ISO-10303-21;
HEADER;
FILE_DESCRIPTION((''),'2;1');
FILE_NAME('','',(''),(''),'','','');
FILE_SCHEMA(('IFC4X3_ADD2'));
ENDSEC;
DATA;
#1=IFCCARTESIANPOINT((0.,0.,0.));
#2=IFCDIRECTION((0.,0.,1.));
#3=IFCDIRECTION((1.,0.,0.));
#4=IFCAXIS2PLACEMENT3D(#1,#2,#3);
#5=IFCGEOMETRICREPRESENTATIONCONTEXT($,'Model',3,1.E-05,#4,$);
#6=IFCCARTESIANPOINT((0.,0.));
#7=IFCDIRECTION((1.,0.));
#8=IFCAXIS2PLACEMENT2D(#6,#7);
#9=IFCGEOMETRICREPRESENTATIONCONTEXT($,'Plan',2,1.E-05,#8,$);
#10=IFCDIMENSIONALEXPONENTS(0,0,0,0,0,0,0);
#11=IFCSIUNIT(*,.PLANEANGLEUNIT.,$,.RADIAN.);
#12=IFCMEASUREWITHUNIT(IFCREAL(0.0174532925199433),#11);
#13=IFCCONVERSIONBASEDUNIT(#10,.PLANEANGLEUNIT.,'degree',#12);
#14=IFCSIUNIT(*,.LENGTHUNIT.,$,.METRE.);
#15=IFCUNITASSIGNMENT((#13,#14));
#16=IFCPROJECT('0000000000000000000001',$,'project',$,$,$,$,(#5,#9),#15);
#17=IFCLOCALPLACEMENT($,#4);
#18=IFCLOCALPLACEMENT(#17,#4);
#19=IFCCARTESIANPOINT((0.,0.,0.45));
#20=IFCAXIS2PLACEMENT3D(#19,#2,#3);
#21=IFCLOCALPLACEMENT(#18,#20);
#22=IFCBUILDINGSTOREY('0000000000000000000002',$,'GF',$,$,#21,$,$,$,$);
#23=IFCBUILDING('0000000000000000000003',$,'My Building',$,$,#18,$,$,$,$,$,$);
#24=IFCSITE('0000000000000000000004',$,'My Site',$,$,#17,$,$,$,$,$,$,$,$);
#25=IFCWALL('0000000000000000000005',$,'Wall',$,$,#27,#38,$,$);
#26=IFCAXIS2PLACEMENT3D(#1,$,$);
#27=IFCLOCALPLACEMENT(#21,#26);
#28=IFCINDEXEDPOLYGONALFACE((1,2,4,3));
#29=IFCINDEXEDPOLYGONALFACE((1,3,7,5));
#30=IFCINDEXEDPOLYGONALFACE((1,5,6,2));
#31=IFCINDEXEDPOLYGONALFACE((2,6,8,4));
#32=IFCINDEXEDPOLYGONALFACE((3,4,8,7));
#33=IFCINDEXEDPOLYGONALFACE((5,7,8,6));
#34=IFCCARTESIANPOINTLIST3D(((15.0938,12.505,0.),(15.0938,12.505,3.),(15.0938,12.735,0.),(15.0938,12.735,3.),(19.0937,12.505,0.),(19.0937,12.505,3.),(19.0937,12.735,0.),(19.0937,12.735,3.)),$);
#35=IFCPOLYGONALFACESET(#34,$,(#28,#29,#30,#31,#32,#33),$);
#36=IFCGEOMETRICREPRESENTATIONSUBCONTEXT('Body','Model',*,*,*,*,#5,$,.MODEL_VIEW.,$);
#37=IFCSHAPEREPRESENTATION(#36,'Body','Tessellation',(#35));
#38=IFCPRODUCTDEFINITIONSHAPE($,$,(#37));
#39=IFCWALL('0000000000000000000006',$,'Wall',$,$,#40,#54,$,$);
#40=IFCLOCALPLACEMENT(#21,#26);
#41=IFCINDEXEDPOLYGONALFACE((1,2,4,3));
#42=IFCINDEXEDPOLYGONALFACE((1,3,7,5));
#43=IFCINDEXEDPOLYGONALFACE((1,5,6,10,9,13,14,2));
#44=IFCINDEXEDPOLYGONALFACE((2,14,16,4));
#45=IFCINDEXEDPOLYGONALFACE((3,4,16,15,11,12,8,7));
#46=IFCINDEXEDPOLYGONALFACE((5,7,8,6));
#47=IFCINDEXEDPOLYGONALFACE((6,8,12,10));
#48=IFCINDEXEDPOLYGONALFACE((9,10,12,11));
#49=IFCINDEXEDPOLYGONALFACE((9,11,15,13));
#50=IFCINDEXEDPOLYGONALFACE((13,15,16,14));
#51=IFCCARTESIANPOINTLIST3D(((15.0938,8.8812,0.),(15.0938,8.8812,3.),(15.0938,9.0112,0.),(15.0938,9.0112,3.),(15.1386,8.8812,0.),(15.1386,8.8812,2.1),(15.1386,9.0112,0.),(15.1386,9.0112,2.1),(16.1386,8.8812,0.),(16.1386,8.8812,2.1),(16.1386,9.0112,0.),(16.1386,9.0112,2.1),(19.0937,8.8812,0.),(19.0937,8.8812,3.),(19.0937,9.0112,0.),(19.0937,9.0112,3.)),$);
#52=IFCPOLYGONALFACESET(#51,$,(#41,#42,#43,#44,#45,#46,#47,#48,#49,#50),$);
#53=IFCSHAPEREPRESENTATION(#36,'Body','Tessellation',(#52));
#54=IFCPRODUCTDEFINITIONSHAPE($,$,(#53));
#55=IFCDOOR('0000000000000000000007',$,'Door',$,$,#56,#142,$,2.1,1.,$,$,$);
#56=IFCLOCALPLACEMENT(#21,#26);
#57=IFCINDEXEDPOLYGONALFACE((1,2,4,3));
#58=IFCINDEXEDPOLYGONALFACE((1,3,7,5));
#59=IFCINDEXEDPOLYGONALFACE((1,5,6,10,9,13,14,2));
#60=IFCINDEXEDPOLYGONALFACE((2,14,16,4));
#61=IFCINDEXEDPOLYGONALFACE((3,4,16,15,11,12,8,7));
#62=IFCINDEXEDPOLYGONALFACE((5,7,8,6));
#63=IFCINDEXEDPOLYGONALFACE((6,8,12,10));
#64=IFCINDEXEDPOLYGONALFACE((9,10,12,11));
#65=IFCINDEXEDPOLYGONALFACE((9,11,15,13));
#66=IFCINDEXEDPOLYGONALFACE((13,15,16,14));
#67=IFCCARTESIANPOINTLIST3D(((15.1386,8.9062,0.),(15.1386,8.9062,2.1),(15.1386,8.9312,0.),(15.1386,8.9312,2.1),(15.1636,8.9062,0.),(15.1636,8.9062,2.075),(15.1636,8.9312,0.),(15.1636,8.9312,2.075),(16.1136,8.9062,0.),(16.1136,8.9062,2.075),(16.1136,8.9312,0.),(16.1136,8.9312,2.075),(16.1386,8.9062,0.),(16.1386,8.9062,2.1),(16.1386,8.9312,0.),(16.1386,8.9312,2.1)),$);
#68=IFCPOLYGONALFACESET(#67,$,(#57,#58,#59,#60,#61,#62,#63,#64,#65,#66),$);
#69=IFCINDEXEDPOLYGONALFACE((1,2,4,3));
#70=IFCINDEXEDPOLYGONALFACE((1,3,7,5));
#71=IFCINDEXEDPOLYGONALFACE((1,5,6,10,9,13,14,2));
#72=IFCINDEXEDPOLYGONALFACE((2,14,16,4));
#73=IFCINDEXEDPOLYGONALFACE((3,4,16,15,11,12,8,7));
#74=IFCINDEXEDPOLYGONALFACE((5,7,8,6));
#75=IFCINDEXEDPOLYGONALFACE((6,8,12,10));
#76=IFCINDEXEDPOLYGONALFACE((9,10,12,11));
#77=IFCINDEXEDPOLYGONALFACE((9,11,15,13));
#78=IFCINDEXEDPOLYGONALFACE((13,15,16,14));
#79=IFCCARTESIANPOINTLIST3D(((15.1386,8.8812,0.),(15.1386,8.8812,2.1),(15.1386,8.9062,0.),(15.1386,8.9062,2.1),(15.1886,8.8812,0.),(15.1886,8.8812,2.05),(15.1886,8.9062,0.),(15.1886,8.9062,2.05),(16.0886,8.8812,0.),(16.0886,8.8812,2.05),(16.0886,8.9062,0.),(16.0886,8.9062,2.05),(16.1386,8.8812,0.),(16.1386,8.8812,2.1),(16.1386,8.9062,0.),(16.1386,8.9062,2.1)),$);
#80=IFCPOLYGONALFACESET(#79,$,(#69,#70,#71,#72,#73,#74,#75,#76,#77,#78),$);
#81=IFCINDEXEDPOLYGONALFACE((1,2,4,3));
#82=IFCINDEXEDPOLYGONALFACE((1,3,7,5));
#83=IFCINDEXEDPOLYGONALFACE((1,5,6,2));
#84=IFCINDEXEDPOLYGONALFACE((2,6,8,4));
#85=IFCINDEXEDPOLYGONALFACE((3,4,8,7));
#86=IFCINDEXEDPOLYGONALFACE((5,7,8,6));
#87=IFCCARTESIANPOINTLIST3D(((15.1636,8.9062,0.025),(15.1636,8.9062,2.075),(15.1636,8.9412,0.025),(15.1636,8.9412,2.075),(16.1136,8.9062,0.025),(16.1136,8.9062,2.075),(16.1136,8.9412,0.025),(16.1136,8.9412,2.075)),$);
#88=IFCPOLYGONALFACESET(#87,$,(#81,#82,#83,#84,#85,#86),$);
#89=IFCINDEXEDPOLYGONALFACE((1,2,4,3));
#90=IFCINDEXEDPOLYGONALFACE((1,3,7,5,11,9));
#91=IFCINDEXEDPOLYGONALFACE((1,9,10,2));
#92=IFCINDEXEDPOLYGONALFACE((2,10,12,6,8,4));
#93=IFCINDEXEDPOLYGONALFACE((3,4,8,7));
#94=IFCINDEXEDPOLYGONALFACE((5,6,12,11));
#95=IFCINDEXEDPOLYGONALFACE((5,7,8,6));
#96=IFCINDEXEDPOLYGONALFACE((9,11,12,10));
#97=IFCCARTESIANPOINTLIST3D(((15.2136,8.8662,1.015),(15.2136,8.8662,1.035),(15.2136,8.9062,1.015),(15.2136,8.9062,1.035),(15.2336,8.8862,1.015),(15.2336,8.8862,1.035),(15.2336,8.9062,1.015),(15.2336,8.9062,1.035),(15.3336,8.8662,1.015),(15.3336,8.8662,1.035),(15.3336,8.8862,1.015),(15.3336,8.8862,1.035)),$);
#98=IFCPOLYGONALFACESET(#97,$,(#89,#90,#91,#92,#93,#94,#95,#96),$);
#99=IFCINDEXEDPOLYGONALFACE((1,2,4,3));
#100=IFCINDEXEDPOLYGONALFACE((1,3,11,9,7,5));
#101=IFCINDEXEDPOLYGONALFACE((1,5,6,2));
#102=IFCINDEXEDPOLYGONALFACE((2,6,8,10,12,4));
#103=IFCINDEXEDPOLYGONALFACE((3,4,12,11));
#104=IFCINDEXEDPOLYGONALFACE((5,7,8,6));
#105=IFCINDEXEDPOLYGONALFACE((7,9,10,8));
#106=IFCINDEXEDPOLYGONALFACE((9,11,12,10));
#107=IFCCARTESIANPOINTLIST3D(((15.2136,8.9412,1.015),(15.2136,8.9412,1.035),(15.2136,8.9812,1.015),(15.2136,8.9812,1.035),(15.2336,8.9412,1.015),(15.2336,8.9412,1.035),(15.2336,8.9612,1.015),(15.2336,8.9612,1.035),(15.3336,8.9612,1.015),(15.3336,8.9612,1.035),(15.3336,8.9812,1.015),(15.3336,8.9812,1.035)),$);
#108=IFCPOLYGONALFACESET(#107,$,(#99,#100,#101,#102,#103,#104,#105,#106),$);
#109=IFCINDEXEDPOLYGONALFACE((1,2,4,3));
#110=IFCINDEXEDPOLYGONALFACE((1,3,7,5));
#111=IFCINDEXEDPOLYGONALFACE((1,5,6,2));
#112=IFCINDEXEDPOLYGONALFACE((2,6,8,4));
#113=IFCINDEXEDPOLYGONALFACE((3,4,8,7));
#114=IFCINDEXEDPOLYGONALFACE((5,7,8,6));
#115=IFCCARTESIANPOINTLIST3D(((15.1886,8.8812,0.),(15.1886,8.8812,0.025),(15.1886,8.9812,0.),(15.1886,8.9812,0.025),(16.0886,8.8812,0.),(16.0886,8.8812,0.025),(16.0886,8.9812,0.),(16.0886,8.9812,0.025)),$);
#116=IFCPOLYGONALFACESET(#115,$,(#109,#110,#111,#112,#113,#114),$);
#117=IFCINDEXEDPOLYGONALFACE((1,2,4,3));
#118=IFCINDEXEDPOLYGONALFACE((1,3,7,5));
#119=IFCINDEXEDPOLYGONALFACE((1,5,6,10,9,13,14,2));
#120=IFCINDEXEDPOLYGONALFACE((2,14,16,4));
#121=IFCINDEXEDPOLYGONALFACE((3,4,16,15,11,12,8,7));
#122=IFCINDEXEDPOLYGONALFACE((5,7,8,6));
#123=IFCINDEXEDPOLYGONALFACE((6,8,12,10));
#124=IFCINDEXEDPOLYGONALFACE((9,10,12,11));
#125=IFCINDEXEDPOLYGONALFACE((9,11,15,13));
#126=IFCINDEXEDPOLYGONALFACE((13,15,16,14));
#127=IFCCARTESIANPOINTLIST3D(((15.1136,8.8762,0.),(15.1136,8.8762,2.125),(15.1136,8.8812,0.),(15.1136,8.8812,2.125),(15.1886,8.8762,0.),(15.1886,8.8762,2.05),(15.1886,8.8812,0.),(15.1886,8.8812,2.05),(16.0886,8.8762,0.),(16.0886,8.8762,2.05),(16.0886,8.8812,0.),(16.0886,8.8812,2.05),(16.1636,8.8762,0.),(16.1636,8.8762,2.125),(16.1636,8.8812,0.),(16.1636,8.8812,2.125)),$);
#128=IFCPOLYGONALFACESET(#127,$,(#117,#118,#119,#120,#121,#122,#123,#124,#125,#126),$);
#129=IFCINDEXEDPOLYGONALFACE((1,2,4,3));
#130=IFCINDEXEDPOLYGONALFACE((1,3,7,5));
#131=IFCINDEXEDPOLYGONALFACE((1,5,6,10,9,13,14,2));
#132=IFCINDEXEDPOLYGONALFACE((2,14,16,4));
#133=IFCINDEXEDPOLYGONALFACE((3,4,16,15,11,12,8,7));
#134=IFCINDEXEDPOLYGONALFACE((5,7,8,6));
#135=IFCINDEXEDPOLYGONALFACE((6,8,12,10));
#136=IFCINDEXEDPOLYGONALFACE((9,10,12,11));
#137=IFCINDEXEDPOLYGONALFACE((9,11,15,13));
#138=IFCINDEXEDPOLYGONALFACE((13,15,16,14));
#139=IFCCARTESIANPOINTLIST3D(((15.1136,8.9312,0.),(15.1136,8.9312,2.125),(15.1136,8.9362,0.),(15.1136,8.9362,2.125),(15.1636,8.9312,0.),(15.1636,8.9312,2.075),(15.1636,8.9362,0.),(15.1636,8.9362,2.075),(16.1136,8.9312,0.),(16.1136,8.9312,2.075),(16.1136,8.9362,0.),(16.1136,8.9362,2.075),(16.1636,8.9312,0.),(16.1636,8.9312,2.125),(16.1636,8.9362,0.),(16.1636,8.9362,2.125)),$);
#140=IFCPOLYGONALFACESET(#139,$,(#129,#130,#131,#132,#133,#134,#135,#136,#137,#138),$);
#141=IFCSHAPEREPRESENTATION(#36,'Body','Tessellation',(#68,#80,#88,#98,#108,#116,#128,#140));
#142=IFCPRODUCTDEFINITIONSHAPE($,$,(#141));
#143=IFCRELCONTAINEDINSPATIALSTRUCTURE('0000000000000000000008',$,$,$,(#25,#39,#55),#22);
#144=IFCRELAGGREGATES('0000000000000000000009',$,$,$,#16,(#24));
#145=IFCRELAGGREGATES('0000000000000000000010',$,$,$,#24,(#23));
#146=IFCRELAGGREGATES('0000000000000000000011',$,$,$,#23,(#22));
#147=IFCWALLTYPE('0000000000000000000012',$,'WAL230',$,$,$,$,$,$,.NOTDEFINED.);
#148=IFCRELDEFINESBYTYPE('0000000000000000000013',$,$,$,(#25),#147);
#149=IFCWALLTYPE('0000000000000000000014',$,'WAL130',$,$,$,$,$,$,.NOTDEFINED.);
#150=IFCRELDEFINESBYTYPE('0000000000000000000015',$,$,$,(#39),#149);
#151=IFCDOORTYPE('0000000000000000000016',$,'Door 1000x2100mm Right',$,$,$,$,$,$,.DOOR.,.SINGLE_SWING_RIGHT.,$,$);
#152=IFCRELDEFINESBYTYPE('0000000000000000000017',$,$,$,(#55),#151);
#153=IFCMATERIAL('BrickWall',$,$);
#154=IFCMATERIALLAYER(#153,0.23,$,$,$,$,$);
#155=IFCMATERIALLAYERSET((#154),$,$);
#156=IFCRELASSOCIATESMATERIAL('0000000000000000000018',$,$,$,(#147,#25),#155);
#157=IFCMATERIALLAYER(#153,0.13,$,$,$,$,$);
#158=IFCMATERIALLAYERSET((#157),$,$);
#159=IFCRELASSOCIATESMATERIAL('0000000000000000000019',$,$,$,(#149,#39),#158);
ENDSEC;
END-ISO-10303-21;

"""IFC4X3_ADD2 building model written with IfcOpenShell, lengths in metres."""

from ifc_helpers import new_model, entity, si_unit, converted_unit, frame, origin_with_axes, origin_2d_with_axis, place, context, subcontext, project, spatial, line, indexed_curve, outline, extrude, shape, source, transform, mapped, material, layer, layer_set, layer_usage, type_object, type_shapes, element, fill, save


model = new_model("IFC4X3_ADD2")

# Units and contexts
model_context = context("Model", 3, precision=1e-05, world=origin_with_axes())
plan_context = context("Plan", 2, precision=1e-05, world=origin_2d_with_axis())
body_context_1 = subcontext(model_context, "Body", "Model", "MODEL_VIEW")
body_context_2 = subcontext(plan_context, "Body", "Plan", "PLAN_VIEW")
ifc_project = project(units=[converted_unit("PLANEANGLEUNIT", "degree", entity("IfcReal", 0.0174532925199433), si_unit("PLANEANGLEUNIT", "RADIAN"), dimensions=[0, 0, 0, 0, 0, 0, 0]), si_unit("LENGTHUNIT", "METRE")], contexts=[model_context, plan_context])

# Site, building, storey
site_placement = place(None, origin_with_axes())
site = spatial("IfcSite", under=ifc_project, at=site_placement, Name="My Site")
building_placement = place(site_placement, origin_with_axes())
building = spatial("IfcBuilding", under=site, at=building_placement, Name="My Building")
storey_placement = place(building_placement, frame((0.0, 0.0, 0.45), z_axis=(0.0, 0.0, 1.0), x_axis=(1.0, 0.0, 0.0)))
storey = spatial("IfcBuildingStorey", under=building, at=storey_placement, Name="GF")

# Shared definitions
ifc_material_1 = material(Name="BrickWall")
ifc_layer_1 = layer(ifc_material_1, 0.23)
ifc_layer_set_1 = layer_set([ifc_layer_1])
wall_type_1 = type_object("IfcWallType", Name="WAL230", PredefinedType="NOTDEFINED", material=ifc_layer_set_1)

# Wall
ifc_layer_usage_1 = layer_usage(ifc_layer_set_1, "AXIS2", "POSITIVE", 0.0)
wall_1_placement = place(storey_placement, frame((19.0937, 12.735, 0.0), z_axis=(0.0, 0.0, 1.0), x_axis=(-1.0, 0.0, 0.0)))
element("IfcWall", 1, at=wall_1_placement, inside=storey, type_object=wall_type_1, material=ifc_layer_usage_1, Name="Wall", context=body_context_1, shape_type="SweptSolid", body=[
    extrude(outline(indexed_curve([(0.0, 0.0), (0.0, 0.23), (3.9999, 0.23), (3.9999, 0.0), (0.0, 0.0)], self_intersect=False)), origin_with_axes(), (0.0, 0.0, 1.0), 3.0),
])

# Wall, opening, door
ifc_layer_2 = layer(ifc_material_1, 0.13)
ifc_layer_set_2 = layer_set([ifc_layer_2])
ifc_layer_usage_2 = layer_usage(ifc_layer_set_2, "AXIS2", "POSITIVE", 0.0)
wall_type_2 = type_object("IfcWallType", Name="WAL130", PredefinedType="NOTDEFINED", material=ifc_layer_set_2)
wall_2_placement = place(storey_placement, frame((15.0938, 8.8812, 0.0), z_axis=(0.0, 0.0, 1.0), x_axis=(1.0, 0.0, 0.0)))
wall_2 = element("IfcWall", 2, at=wall_2_placement, inside=storey, type_object=wall_type_2, material=ifc_layer_usage_2, Name="Wall", context=body_context_1, shape_type="SweptSolid", body=[
    extrude(outline(indexed_curve([(0.0, 0.0), (0.0, 0.13), (3.9999, 0.13), (3.9999, 0.0), (0.0, 0.0)], self_intersect=False)), origin_with_axes(), (0.0, 0.0, 1.0), 3.0),
])
shared_shape_1 = source(origin_with_axes(), body_context_1, "Body", "SweptSolid", [
    extrude(outline(indexed_curve([(0.0, 0.0), (1.0, 0.0), (1.0, 2.1), (0.0, 2.1)], segments=[line(1, 2, 3, 4, 1)])), frame((0.0, -0.6, 0.0), z_axis=(0.0, -1.0, 0.0), x_axis=(1.0, 0.0, 0.0)), (0.0, 0.0, -1.0), 1.2),
])
opening_1_placement = place(wall_2_placement, frame((0.0447, 0.0, 0.0), z_axis=(0.0, 0.0, 1.0), x_axis=(1.0, 0.0, 0.0)))
opening_1 = element("IfcOpeningElement", 3, at=opening_1_placement, cuts=wall_2, PredefinedType="OPENING", context=body_context_1, shape_type="MappedRepresentation", body=[
    mapped(shared_shape_1, transform((0.0, 0.0, 0.0), x_axis=(1.0, 0.0, 0.0), y_axis=(0.0, 1.0, 0.0), z_axis=(0.0, 0.0, 1.0), scale=1.0)),
])
door_type_1 = type_object("IfcDoorType", Name="Door 1000x2100mm Right", OperationType="SINGLE_SWING_RIGHT", PredefinedType="DOOR")
shared_shape_2 = source(origin_with_axes(), body_context_1, "Body", "SweptSolid", [
    extrude(outline(indexed_curve([(0.0, 0.0), (0.0, 2.1), (1.0, 2.1), (1.0, 0.0), (0.975, 0.0), (0.975, 2.075), (0.025, 2.075), (0.025, 0.0)], segments=[line(1, 2, 3, 4, 5, 6, 7, 8, 1)])), frame((0.0, 0.025, 0.0), z_axis=(0.0, -1.0, 0.0), x_axis=(1.0, 0.0, 0.0)), (0.0, 0.0, -1.0), 0.025),
    extrude(outline(indexed_curve([(0.0, 0.0), (0.0, 2.1), (1.0, 2.1), (1.0, 0.0), (0.95, 0.0), (0.95, 2.05), (0.05, 2.05), (0.05, 0.0)], segments=[line(1, 2, 3, 4, 5, 6, 7, 8, 1)])), frame((0.0, 0.0, 0.0), z_axis=(0.0, -1.0, 0.0), x_axis=(1.0, 0.0, 0.0)), (0.0, 0.0, -1.0), 0.025),
    extrude(outline(indexed_curve([(0.0, 0.0), (0.95, 0.0), (0.95, 0.035), (0.0, 0.035)], segments=[line(1, 2, 3, 4, 1)])), frame((0.025, 0.025, 0.025), z_axis=(0.0, 0.0, 1.0), x_axis=(1.0, 0.0, 0.0)), (0.0, 0.0, 1.0), 2.05),
    extrude(outline(indexed_curve([(0.0, 0.0), (0.0, -0.04), (0.12, -0.04), (0.12, -0.02), (0.02, -0.02), (0.02, 0.0)], segments=[line(1, 2, 3, 4, 5, 6, 1)])), frame((0.075, 0.025, 1.015), z_axis=(0.0, 0.0, 1.0), x_axis=(1.0, 0.0, 0.0)), (0.0, 0.0, 1.0), 0.02),
    extrude(outline(indexed_curve([(0.0, 0.0), (0.0, 0.04), (0.12, 0.04), (0.12, 0.02), (0.02, 0.02), (0.02, 0.0)], segments=[line(1, 2, 3, 4, 5, 6, 1)])), frame((0.075, 0.06, 1.015), z_axis=(0.0, 0.0, 1.0), x_axis=(1.0, 0.0, 0.0)), (0.0, 0.0, 1.0), 0.02),
    extrude(outline(indexed_curve([(0.0, 0.0), (0.9, 0.0), (0.9, 0.1), (0.0, 0.1)], segments=[line(1, 2, 3, 4, 1)])), frame((0.05, 0.0, 0.0), z_axis=(0.0, 0.0, 1.0), x_axis=(1.0, 0.0, 0.0)), (0.0, 0.0, 1.0), 0.025),
    extrude(outline(indexed_curve([(0.0, 0.0), (0.0, 2.125), (1.05, 2.125), (1.05, 0.0), (0.975, 0.0), (0.975, 2.05), (0.075, 2.05), (0.075, 0.0)], segments=[line(1, 2, 3, 4, 5, 6, 7, 8, 1)])), frame((-0.025, -0.005, 0.0), z_axis=(0.0, -1.0, 0.0), x_axis=(1.0, 0.0, 0.0)), (0.0, 0.0, -1.0), 0.005),
    extrude(outline(indexed_curve([(0.0, 0.0), (0.0, 2.125), (1.05, 2.125), (1.05, 0.0), (1.0, 0.0), (1.0, 2.075), (0.05, 2.075), (0.05, 0.0)], segments=[line(1, 2, 3, 4, 5, 6, 7, 8, 1)])), frame((-0.025, 0.05, 0.0), z_axis=(0.0, -1.0, 0.0), x_axis=(1.0, 0.0, 0.0)), (0.0, 0.0, -1.0), 0.005),
])
shared_shape_3 = source(origin_with_axes(), body_context_2, "Body", "Curve2D", [
    entity("IfcIndexedPolyCurve", entity("IfcCartesianPointList2D", [[0.0, 0.0], [0.0, 0.05], [0.025, 0.05], [0.025, 0.025], [0.05, 0.025], [0.05, 0.0]]), [entity("IfcLineIndex", [1, 2, 3, 4, 5, 6, 1])]),
    entity("IfcIndexedPolyCurve", entity("IfcCartesianPointList2D", [[1.0, 0.0], [1.0, 0.05], [0.975, 0.05], [0.975, 0.025], [0.95, 0.025], [0.95, 0.0]]), [entity("IfcLineIndex", [1, 2, 3, 4, 5, 6, 1])]),
    entity("IfcTrimmedCurve", entity("IfcEllipse", entity("IfcAxis2Placement2D", entity("IfcCartesianPoint", [0.94, 0.05]), entity("IfcDirection", [1.0, 0.0])), 0.915, 0.95), [entity("IfcCartesianPoint", [0.94, 1.0])], [entity("IfcCartesianPoint", [0.025, 0.05])], True, "CARTESIAN"),
    entity("IfcIndexedPolyCurve", entity("IfcCartesianPointList2D", [[0.975, 0.05], [0.94, 0.05], [0.94, 1.0], [0.975, 1.0]]), [entity("IfcLineIndex", [1, 2, 3, 4, 1])]),
])
type_shapes(door_type_1, [shared_shape_2, shared_shape_3])
door_1_placement = place(opening_1_placement, origin_with_axes())
door_1 = element("IfcDoor", 4, at=door_1_placement, inside=storey, type_object=door_type_1, Name="Door", OverallHeight=2.1, OverallWidth=1.0, shapes=[
    shape(body_context_1, "Body", "MappedRepresentation", [mapped(shared_shape_2, transform((0.0, 0.0, 0.0), x_axis=(1.0, 0.0, 0.0), y_axis=(0.0, 1.0, 0.0), z_axis=(0.0, 0.0, 1.0), scale=1.0))]),
    shape(body_context_2, "Body", "MappedRepresentation", [mapped(shared_shape_3, transform((0.0, 0.0, 0.0), x_axis=(1.0, 0.0, 0.0), y_axis=(0.0, 1.0, 0.0), z_axis=(0.0, 0.0, 1.0), scale=1.0))]),
])
fill(opening_1, door_1)

save(model, "model.ifc")
